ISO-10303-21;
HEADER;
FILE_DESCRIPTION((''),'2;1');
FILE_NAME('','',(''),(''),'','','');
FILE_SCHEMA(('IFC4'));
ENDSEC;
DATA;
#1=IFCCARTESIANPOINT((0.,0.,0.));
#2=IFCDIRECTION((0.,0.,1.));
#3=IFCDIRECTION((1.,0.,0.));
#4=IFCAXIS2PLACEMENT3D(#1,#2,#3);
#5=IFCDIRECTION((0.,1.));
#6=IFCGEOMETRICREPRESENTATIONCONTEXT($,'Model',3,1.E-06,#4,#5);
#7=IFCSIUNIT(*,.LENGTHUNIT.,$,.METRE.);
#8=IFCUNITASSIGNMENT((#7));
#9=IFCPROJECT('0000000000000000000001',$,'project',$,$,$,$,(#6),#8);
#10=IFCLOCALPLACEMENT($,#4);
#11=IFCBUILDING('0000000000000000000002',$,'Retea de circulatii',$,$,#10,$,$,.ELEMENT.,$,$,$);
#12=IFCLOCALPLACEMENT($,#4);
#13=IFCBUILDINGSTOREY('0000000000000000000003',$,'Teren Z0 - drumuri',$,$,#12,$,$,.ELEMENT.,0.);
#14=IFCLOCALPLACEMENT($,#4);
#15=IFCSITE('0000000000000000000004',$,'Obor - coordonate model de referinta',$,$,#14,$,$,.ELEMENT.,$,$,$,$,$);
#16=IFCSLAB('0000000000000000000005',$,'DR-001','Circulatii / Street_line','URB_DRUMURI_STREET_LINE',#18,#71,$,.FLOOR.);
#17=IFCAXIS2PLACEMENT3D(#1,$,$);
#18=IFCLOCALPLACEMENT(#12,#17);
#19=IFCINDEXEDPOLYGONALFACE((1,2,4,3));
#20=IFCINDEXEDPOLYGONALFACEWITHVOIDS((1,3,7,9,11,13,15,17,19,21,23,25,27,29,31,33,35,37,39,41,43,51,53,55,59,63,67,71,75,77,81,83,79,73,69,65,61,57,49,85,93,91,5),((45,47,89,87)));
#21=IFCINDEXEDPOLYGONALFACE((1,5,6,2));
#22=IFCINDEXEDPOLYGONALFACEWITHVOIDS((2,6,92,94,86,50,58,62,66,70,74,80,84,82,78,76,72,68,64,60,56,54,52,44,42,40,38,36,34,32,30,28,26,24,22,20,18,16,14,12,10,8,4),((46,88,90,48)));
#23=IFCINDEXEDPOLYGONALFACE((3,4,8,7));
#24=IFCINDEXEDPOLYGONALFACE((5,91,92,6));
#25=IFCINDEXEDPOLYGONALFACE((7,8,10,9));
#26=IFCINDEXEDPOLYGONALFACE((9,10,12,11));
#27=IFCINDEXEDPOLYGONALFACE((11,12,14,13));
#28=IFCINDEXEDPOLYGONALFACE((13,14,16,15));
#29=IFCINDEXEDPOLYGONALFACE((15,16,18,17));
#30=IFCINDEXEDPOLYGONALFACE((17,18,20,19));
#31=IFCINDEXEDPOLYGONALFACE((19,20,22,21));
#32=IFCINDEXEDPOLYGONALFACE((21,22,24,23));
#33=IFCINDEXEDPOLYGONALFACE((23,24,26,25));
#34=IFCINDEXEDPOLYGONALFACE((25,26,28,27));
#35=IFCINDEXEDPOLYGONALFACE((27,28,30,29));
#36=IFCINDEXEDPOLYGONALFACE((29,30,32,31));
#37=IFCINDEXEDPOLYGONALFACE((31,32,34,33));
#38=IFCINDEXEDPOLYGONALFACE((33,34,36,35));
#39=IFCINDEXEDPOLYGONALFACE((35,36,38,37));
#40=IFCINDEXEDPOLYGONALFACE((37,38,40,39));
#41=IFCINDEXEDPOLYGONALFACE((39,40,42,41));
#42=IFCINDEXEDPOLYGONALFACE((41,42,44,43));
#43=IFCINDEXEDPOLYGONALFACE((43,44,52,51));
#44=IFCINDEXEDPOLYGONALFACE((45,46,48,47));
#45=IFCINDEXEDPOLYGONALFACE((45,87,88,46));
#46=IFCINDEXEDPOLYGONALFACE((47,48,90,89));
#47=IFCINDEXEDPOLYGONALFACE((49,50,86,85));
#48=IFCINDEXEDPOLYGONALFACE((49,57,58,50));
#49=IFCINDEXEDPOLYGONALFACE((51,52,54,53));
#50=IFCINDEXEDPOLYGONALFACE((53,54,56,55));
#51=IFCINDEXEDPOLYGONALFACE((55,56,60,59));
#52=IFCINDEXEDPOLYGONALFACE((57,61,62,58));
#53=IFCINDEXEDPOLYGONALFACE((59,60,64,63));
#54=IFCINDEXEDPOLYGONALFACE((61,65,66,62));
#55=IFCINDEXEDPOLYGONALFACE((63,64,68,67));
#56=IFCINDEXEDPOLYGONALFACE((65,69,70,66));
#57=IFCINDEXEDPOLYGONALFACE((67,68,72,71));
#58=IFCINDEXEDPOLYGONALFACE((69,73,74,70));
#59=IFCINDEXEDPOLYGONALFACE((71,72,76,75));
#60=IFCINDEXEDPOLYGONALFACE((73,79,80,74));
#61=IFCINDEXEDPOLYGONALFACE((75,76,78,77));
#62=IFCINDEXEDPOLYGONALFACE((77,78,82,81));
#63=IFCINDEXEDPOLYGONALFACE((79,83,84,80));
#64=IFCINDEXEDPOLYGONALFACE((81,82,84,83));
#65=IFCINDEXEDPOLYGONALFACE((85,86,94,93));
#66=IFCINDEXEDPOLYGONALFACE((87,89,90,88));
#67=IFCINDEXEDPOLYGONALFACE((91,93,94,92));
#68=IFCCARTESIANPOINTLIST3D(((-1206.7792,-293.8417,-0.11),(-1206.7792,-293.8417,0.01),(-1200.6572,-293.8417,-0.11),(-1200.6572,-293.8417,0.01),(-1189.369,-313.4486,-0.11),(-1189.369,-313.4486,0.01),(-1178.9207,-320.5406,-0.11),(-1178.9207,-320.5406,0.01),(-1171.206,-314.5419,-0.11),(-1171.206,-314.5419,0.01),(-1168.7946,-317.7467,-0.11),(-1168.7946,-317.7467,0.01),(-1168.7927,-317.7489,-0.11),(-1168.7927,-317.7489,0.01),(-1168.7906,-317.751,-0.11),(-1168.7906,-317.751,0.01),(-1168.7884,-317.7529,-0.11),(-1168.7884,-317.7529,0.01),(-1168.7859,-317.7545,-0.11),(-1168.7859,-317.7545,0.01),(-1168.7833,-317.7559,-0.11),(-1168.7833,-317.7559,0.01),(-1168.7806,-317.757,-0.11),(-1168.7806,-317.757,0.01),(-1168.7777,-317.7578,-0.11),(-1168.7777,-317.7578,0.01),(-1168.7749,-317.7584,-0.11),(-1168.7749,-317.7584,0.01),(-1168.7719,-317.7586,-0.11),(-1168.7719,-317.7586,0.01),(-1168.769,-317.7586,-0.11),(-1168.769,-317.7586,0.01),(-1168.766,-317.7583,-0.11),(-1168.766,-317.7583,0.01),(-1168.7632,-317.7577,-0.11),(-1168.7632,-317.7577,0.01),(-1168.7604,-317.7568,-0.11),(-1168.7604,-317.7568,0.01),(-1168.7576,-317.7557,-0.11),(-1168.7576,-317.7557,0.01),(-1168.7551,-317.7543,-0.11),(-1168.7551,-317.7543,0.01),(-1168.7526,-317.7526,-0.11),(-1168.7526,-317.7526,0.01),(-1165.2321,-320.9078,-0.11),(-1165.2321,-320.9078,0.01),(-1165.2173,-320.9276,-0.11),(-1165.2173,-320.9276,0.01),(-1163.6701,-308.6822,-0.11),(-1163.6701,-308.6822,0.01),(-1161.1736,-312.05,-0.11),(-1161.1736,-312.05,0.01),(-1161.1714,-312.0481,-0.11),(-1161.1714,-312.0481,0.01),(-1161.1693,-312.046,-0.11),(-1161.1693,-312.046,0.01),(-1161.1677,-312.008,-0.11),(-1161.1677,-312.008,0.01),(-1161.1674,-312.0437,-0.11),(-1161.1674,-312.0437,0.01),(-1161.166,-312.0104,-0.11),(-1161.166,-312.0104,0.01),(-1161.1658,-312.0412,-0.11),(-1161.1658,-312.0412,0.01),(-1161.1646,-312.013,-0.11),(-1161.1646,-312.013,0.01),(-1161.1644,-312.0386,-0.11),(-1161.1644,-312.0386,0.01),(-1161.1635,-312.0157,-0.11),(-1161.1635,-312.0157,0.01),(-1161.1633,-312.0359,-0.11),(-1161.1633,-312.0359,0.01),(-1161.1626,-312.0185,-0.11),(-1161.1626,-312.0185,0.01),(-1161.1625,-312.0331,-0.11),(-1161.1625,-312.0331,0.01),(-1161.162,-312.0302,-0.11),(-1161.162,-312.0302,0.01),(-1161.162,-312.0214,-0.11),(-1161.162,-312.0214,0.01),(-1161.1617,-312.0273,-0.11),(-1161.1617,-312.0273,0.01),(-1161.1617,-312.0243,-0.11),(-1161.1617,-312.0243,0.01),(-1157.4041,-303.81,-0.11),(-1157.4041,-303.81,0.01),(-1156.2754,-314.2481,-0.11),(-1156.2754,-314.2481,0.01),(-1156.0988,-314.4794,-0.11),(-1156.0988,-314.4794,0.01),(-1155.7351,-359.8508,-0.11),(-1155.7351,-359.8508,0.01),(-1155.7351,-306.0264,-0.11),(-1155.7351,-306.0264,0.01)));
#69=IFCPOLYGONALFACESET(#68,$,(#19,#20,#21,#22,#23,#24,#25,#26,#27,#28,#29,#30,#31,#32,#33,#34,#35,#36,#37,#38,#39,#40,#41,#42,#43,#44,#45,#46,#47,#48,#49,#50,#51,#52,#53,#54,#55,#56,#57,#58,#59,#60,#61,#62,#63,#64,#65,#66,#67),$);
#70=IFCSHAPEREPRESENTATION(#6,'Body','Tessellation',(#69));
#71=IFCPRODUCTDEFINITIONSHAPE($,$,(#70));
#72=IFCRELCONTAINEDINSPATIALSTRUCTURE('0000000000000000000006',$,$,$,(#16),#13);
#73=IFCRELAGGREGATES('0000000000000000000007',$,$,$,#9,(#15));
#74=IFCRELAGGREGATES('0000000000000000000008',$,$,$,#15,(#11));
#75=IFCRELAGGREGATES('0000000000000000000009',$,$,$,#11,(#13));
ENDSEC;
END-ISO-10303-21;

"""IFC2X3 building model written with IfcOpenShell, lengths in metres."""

from ifc_helpers import new_model, si_unit, direction, frame, origin_with_axes, place, context, project, spatial, polyline, outline, extrude, element, save


model = new_model("IFC2X3")

# Units and contexts
model_context = context("Model", 3, precision=1e-06, world=origin_with_axes(), true_north=direction((0.0, 1.0)))
ifc_project = project(units=[si_unit("LENGTHUNIT", "METRE")], contexts=[model_context])

# Site, building, storey
site_placement = place(None, origin_with_axes())
site = spatial("IfcSite", under=ifc_project, at=site_placement, Name="Obor - coordonate model de referinta", CompositionType="ELEMENT")
building_placement = place(None, origin_with_axes())
building = spatial("IfcBuilding", under=site, at=building_placement, Name="Retea de circulatii", CompositionType="ELEMENT")
storey_placement = place(None, origin_with_axes())
storey = spatial("IfcBuildingStorey", under=building, at=storey_placement, Name="Teren Z0 - drumuri", CompositionType="ELEMENT", Elevation=0.0)

# Slab
slab_1_placement = place(None, origin_with_axes())
element("IfcSlab", 1, at=slab_1_placement, inside=storey, Name="DR-001", Description="Circulatii / Street_line", ObjectType="URB_DRUMURI_STREET_LINE", PredefinedType="FLOOR", context=model_context, shape_type="SweptSolid", body=[
    extrude(outline(polyline([(-1189.369, -313.4486), (-1155.7351, -359.8508), (-1155.7351, -306.0264), (-1157.4041, -303.81), (-1163.6701, -308.6822), (-1161.1677, -312.008), (-1161.166, -312.0104), (-1161.1646, -312.013), (-1161.1635, -312.0157), (-1161.1626, -312.0185), (-1161.162, -312.0214), (-1161.1617, -312.0243), (-1161.1617, -312.0273), (-1161.162, -312.0302), (-1161.1625, -312.0331), (-1161.1633, -312.0359), (-1161.1644, -312.0386), (-1161.1658, -312.0412), (-1161.1674, -312.0437), (-1161.1693, -312.046), (-1161.1714, -312.0481), (-1161.1736, -312.05), (-1168.7526, -317.7526), (-1168.7551, -317.7543), (-1168.7576, -317.7557), (-1168.7604, -317.7568), (-1168.7632, -317.7577), (-1168.766, -317.7583), (-1168.769, -317.7586), (-1168.7719, -317.7586), (-1168.7749, -317.7584), (-1168.7777, -317.7578), (-1168.7806, -317.757), (-1168.7833, -317.7559), (-1168.7859, -317.7545), (-1168.7884, -317.7529), (-1168.7906, -317.751), (-1168.7927, -317.7489), (-1168.7946, -317.7467), (-1171.206, -314.5419), (-1178.9207, -320.5406), (-1200.6572, -293.8417), (-1206.7792, -293.8417), (-1189.369, -313.4486)]), holes=[polyline([(-1156.0988, -314.4794), (-1165.2173, -320.9276), (-1165.2321, -320.9078), (-1156.2754, -314.2481), (-1156.0988, -314.4794)])]), frame((0.0, 0.0, -0.11), z_axis=(0.0, 0.0, 1.0), x_axis=(1.0, 0.0, 0.0)), (0.0, 0.0, 1.0), 0.12),
])

save(model, "model.ifc")
